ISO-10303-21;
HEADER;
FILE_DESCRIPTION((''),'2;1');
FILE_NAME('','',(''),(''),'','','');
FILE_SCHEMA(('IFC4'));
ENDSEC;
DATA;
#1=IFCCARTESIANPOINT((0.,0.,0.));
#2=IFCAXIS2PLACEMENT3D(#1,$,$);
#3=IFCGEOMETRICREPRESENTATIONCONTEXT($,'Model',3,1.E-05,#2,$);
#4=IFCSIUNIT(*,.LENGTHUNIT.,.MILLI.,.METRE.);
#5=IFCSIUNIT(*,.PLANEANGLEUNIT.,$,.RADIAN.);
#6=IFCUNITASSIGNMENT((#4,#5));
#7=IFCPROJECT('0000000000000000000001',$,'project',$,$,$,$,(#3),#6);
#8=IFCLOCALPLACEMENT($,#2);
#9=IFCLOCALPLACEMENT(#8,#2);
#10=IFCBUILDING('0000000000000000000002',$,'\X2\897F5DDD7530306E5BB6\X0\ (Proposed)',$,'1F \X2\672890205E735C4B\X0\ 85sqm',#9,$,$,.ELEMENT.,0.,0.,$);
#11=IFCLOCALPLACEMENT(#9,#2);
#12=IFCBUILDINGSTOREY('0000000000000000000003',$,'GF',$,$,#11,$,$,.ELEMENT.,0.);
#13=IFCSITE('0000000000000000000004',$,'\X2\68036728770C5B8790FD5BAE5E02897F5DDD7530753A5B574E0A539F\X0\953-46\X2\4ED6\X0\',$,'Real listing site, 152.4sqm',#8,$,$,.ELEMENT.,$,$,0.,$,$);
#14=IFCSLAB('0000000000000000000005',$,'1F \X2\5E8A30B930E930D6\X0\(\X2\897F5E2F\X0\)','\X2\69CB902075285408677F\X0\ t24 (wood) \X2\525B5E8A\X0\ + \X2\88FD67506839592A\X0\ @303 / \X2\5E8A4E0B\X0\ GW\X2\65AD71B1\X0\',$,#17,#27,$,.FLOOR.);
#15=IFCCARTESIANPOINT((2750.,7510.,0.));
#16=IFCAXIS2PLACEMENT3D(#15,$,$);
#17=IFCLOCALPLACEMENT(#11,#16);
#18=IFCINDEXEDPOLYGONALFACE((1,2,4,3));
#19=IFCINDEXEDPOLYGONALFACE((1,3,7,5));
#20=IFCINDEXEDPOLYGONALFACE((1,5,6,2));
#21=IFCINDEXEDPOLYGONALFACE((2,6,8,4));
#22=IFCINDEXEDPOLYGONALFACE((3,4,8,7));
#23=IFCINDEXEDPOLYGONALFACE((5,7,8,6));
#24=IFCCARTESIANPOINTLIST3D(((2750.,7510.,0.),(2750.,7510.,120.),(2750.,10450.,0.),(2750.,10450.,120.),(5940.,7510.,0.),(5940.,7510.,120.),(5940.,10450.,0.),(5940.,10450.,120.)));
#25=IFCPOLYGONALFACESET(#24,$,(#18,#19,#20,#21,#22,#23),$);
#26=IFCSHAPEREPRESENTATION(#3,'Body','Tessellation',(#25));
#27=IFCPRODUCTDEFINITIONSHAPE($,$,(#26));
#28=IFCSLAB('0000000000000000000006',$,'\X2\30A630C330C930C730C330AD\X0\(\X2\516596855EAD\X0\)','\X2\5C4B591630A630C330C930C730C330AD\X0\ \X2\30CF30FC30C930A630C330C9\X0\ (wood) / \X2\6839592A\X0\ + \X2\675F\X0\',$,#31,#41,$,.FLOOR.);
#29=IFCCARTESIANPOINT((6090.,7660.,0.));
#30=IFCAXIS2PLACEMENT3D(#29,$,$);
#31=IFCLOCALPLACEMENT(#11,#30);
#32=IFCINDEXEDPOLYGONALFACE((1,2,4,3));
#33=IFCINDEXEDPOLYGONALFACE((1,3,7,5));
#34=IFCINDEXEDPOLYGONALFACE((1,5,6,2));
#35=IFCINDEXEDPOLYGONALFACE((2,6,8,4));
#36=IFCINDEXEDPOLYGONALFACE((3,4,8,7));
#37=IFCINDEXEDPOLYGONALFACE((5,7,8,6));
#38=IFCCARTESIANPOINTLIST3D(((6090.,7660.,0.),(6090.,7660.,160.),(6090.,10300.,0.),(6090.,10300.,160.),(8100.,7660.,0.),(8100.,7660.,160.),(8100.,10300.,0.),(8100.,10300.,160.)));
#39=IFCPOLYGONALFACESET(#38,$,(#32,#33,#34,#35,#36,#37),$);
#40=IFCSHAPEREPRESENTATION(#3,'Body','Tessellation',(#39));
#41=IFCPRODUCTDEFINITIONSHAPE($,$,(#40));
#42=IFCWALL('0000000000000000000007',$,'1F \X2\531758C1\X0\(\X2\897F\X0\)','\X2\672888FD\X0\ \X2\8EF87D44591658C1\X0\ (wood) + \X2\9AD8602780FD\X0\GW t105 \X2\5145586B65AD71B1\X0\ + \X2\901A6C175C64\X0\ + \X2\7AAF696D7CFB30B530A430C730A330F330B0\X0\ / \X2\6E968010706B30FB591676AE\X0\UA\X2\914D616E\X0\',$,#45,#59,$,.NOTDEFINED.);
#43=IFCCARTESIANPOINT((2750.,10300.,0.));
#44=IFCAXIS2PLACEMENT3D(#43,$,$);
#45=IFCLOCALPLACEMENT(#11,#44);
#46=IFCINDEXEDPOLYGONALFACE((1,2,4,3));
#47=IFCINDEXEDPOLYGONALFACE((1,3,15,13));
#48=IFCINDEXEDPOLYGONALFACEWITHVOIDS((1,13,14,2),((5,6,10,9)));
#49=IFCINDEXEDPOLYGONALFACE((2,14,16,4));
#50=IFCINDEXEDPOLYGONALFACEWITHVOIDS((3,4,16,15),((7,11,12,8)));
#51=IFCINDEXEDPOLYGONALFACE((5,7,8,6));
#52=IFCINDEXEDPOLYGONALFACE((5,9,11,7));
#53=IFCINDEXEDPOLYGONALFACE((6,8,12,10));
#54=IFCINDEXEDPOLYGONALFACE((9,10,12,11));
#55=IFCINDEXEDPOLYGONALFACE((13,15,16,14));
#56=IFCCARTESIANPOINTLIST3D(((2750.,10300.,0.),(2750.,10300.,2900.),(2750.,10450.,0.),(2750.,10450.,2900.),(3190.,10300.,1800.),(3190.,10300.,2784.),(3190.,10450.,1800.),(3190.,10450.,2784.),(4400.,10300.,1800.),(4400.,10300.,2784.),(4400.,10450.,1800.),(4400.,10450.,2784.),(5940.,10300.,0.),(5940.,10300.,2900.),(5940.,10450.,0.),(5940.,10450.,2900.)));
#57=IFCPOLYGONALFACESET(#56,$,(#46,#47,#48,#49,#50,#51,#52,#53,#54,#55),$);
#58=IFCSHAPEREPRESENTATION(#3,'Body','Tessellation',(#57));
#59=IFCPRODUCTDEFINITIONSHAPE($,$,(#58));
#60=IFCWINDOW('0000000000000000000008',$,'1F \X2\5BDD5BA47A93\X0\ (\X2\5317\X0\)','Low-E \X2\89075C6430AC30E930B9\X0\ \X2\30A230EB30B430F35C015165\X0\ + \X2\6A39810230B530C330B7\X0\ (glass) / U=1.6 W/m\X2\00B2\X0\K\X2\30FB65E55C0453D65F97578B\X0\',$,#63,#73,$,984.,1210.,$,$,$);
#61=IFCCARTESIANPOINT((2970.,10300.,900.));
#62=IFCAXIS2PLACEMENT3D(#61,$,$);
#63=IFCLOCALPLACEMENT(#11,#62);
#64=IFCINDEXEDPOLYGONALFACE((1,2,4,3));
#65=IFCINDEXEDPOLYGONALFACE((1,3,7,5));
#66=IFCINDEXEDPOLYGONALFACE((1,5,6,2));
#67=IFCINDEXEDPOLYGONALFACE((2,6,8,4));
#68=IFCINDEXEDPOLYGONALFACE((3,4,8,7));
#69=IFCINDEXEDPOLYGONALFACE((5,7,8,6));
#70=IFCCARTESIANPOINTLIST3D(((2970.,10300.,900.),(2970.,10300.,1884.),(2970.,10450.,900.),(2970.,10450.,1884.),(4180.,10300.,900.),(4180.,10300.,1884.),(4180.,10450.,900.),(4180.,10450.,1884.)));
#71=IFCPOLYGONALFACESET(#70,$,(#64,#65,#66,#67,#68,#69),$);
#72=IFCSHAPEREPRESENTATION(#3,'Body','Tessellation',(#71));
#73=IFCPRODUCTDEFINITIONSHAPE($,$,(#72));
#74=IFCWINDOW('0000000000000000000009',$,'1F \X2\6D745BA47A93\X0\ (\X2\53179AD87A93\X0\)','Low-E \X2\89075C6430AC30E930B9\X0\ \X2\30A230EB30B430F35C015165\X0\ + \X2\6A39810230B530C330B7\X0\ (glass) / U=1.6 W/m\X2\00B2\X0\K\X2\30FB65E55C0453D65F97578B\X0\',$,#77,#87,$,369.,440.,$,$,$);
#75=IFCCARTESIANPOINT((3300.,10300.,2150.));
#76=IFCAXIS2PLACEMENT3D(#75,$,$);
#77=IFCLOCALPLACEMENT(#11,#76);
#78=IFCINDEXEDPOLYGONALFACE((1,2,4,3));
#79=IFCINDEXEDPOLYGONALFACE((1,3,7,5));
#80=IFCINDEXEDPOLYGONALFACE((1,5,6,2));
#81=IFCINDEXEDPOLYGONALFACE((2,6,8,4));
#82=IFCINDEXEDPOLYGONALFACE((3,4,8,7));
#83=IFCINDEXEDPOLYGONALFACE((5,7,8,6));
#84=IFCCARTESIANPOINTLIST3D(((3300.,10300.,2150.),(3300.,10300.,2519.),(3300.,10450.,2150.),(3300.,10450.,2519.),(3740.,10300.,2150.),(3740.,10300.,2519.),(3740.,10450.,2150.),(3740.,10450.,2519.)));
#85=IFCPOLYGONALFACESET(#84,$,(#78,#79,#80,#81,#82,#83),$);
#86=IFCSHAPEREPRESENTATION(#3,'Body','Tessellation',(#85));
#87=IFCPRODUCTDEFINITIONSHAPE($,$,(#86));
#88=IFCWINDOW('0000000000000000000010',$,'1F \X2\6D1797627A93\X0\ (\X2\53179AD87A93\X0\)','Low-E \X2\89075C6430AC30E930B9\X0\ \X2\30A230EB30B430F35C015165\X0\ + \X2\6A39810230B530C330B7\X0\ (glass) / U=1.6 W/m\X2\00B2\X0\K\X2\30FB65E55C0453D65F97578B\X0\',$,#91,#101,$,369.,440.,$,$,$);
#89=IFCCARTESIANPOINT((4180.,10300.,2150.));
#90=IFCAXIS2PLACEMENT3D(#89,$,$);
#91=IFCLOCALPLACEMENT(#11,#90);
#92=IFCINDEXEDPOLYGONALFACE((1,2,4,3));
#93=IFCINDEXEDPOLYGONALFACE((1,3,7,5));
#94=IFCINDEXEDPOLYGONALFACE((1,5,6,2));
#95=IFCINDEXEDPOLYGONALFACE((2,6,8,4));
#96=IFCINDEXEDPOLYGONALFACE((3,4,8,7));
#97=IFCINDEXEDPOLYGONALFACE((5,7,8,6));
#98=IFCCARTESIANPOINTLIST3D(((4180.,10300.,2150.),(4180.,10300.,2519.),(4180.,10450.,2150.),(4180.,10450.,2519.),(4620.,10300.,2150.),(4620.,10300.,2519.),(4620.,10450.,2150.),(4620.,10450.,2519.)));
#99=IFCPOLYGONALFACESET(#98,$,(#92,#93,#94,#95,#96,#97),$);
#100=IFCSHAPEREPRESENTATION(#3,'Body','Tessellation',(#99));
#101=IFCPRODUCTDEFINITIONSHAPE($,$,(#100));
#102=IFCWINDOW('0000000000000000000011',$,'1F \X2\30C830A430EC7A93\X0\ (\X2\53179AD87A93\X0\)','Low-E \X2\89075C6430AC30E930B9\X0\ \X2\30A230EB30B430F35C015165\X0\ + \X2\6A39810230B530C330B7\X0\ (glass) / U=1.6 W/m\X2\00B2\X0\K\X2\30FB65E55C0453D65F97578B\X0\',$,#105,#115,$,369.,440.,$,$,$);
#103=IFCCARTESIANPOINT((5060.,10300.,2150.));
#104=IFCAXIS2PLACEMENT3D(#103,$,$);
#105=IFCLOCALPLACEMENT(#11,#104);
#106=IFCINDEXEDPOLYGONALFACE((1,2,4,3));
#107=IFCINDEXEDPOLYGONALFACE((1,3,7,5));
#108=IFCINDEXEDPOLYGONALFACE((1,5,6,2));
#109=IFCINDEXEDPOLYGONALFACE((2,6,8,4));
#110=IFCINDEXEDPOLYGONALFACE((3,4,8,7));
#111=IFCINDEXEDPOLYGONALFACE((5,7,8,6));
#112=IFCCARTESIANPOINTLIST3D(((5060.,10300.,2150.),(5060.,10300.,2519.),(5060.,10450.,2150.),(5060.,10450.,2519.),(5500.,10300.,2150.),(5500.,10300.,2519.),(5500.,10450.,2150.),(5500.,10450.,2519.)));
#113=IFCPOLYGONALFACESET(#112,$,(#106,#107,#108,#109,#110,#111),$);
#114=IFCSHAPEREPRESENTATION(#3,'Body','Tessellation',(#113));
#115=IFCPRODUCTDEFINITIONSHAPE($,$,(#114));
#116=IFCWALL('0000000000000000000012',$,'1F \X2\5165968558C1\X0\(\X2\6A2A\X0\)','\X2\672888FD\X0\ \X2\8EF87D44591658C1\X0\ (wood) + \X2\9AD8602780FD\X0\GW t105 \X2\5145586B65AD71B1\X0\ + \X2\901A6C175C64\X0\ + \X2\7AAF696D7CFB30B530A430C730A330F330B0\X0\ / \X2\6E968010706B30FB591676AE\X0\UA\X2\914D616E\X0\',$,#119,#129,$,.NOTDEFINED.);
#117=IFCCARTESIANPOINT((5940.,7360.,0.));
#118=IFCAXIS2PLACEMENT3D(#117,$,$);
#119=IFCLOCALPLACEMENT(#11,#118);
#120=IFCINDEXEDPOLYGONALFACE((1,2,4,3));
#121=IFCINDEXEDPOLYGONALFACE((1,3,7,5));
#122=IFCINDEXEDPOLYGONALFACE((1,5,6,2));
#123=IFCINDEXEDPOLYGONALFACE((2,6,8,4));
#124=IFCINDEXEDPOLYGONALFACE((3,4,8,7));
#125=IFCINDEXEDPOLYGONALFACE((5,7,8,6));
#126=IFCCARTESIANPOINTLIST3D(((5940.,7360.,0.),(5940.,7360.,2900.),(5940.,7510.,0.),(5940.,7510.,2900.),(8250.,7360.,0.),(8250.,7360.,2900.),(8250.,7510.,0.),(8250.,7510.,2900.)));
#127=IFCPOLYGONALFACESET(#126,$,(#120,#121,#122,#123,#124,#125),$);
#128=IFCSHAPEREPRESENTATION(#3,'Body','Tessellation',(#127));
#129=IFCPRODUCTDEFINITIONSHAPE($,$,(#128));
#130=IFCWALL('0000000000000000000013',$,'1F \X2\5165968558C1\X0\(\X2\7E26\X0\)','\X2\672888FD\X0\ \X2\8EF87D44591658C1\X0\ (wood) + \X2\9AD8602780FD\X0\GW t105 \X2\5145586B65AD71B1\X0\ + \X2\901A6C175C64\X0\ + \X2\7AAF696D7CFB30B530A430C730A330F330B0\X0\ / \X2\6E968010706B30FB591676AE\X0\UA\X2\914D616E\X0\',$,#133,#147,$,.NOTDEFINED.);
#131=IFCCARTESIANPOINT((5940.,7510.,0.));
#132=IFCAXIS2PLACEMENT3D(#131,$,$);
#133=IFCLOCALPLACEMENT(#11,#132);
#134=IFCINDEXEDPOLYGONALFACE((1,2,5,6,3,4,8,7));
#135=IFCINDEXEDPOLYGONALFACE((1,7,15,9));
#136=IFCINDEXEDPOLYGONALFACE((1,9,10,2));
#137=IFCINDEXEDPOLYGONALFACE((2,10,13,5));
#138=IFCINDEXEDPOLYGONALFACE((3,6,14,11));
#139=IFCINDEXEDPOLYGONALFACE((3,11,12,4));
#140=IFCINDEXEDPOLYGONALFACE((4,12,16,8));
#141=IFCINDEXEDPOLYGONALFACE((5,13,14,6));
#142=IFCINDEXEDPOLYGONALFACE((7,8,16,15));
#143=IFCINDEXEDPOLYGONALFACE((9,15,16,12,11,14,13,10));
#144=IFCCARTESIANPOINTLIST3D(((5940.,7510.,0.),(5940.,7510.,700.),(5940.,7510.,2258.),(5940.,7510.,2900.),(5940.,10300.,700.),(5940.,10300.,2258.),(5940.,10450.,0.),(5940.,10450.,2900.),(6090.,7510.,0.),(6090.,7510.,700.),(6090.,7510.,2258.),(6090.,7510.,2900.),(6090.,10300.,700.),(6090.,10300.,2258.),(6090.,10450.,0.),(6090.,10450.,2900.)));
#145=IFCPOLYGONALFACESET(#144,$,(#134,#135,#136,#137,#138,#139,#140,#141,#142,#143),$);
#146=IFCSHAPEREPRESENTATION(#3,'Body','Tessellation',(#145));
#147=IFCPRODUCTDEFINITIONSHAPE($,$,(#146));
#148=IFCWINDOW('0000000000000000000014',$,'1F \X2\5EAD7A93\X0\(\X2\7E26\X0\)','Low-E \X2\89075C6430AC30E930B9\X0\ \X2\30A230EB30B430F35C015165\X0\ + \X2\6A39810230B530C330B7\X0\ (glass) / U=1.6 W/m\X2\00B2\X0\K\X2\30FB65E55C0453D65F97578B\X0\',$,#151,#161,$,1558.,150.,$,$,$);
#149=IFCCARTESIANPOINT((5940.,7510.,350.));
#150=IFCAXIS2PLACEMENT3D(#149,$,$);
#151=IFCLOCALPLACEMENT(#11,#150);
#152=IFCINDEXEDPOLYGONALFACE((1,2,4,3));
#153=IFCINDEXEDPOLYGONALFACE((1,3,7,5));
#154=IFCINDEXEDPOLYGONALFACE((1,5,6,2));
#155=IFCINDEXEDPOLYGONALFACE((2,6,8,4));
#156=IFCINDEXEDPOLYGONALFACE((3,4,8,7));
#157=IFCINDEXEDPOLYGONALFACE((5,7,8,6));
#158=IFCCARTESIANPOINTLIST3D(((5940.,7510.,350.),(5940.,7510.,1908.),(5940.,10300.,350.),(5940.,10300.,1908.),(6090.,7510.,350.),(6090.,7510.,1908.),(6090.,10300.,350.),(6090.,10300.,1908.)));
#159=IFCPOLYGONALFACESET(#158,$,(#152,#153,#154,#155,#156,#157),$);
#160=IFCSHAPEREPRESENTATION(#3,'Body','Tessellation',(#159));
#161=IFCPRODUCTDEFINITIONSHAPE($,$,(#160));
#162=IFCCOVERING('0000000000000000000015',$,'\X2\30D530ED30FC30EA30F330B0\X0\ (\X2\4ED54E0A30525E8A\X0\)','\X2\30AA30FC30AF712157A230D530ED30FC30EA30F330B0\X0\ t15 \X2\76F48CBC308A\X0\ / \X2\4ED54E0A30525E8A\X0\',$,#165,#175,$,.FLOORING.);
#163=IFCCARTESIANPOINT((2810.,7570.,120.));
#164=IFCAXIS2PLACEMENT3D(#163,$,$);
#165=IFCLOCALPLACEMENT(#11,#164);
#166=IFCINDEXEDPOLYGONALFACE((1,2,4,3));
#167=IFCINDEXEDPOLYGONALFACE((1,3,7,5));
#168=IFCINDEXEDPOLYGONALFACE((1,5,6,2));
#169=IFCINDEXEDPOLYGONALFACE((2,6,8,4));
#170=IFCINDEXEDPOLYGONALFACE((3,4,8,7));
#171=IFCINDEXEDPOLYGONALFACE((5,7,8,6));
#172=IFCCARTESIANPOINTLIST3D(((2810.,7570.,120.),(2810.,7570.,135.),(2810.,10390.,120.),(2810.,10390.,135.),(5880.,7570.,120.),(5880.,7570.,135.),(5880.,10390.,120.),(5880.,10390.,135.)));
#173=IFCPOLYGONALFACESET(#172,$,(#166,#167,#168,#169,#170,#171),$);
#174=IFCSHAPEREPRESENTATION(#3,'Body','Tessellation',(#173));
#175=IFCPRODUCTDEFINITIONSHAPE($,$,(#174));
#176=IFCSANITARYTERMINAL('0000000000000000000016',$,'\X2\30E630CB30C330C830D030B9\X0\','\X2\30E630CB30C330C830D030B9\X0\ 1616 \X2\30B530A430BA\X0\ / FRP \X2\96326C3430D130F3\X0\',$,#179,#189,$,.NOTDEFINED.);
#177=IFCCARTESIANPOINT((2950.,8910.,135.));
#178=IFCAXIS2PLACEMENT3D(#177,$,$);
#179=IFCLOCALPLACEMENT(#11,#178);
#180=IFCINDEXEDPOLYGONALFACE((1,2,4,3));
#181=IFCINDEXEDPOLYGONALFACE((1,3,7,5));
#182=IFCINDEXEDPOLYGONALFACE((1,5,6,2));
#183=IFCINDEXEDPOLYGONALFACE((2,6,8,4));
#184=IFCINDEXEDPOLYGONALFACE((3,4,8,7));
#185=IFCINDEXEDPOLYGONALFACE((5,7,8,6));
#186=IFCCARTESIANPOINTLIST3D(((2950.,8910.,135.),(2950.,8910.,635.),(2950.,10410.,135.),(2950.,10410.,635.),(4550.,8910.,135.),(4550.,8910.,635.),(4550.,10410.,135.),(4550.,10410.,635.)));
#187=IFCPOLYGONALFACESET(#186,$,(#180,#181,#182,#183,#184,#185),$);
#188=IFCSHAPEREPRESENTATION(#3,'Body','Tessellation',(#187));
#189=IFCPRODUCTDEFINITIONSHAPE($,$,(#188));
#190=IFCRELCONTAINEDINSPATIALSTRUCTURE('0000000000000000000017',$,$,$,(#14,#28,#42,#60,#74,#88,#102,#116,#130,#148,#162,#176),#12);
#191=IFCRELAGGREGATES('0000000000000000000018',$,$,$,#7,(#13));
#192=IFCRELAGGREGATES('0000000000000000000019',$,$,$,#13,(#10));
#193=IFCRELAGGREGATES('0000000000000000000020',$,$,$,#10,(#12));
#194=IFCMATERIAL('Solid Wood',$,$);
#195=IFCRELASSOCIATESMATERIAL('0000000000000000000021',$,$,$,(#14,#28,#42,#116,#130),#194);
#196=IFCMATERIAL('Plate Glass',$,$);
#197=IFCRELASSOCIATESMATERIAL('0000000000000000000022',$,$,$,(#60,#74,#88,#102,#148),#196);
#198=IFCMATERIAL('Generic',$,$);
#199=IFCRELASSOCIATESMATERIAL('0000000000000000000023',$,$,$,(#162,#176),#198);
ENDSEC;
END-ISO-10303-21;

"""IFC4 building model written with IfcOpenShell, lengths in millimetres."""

from ifc_helpers import new_model, si_unit, frame, frame_2d, origin, place, context, project, spatial, rectangle, extrude, material, element, fill, save


model = new_model("IFC4")

# Units and contexts
model_context = context("Model", 3, precision=1e-05, world=origin())
ifc_project = project(units=[si_unit("LENGTHUNIT", "METRE", prefix="MILLI"), si_unit("PLANEANGLEUNIT", "RADIAN")], contexts=[model_context])

# Site, building, storey
site_placement = place(None, origin())
site = spatial("IfcSite", under=ifc_project, at=site_placement, Name="栃木県宇都宮市西川田町字上原953-46他", ObjectType="Real listing site, 152.4sqm", CompositionType="ELEMENT", RefElevation=0.0)
building_placement = place(site_placement, origin())
building = spatial("IfcBuilding", under=site, at=building_placement, Name="西川田の家 (Proposed)", ObjectType="1F 木造平屋 85sqm", CompositionType="ELEMENT", ElevationOfRefHeight=0.0, ElevationOfTerrain=0.0)
storey_placement = place(building_placement, origin())
storey = spatial("IfcBuildingStorey", under=building, at=storey_placement, Name="GF", CompositionType="ELEMENT", Elevation=0.0)

# Slabs
ifc_material_1 = material(Name="Solid Wood")
slab_1_placement = place(storey_placement, frame((2750.0, 7510.0, 0.0)))
element("IfcSlab", 1, at=slab_1_placement, inside=storey, material=ifc_material_1, Name="1F 床スラブ(西帯)", Description="構造用合板 t24 (wood) 剛床 + 製材根太 @303 / 床下 GW断熱", PredefinedType="FLOOR", context=model_context, shape_type="SweptSolid", body=[
    extrude(rectangle(XDim=3190.0, YDim=2940.0, at=frame_2d((1595.0, 1470.0))), frame((2750.0, 7510.0, 0.0)), (0.0, 0.0, 1.0), 120.0),
])
slab_2_placement = place(storey_placement, frame((6090.0, 7660.0, 0.0)))
element("IfcSlab", 2, at=slab_2_placement, inside=storey, material=ifc_material_1, Name="ウッドデッキ(入隅庭)", Description="屋外ウッドデッキ ハードウッド (wood) / 根太 + 束", PredefinedType="FLOOR", context=model_context, shape_type="SweptSolid", body=[
    extrude(rectangle(XDim=2010.0, YDim=2640.0, at=frame_2d((1005.0, 1320.0))), frame((6090.0, 7660.0, 0.0)), (0.0, 0.0, 1.0), 160.0),
])

# Wall, openings, windows
wall_1_placement = place(storey_placement, frame((2750.0, 10300.0, 0.0)))
wall_1 = element("IfcWall", 3, at=wall_1_placement, inside=storey, material=ifc_material_1, Name="1F 北壁(西)", Description="木製 軸組外壁 (wood) + 高性能GW t105 充填断熱 + 通気層 + 窯業系サイディング / 準耐火・外皮UA配慮", PredefinedType="NOTDEFINED", context=model_context, shape_type="SweptSolid", body=[
    extrude(rectangle(XDim=3190.0, YDim=150.0, at=frame_2d((1595.0, 75.0))), frame((2750.0, 10300.0, 0.0)), (0.0, 0.0, 1.0), 2900.0),
])
opening_1_placement = place(storey_placement, frame((2970.0, 10300.0, 900.0)))
opening_1 = element("IfcOpeningElement", 4, at=opening_1_placement, cuts=wall_1, PredefinedType="NOTDEFINED", context=model_context, shape_type="SweptSolid", body=[
    extrude(rectangle(XDim=1210.0, YDim=150.0, at=frame_2d((605.0, 75.0))), frame((2970.0, 10300.0, 900.0)), (0.0, 0.0, 1.0), 984.0),
])
opening_2_placement = place(storey_placement, frame((3300.0, 10300.0, 2150.0)))
opening_2 = element("IfcOpeningElement", 5, at=opening_2_placement, cuts=wall_1, PredefinedType="NOTDEFINED", context=model_context, shape_type="SweptSolid", body=[
    extrude(rectangle(XDim=440.0, YDim=150.0, at=frame_2d((220.0, 75.0))), frame((3300.0, 10300.0, 2150.0)), (0.0, 0.0, 1.0), 369.0),
])
opening_3_placement = place(storey_placement, frame((4180.0, 10300.0, 2150.0)))
opening_3 = element("IfcOpeningElement", 6, at=opening_3_placement, cuts=wall_1, PredefinedType="NOTDEFINED", context=model_context, shape_type="SweptSolid", body=[
    extrude(rectangle(XDim=440.0, YDim=150.0, at=frame_2d((220.0, 75.0))), frame((4180.0, 10300.0, 2150.0)), (0.0, 0.0, 1.0), 369.0),
])
opening_4_placement = place(storey_placement, frame((5060.0, 10300.0, 2150.0)))
opening_4 = element("IfcOpeningElement", 7, at=opening_4_placement, cuts=wall_1, PredefinedType="NOTDEFINED", context=model_context, shape_type="SweptSolid", body=[
    extrude(rectangle(XDim=440.0, YDim=150.0, at=frame_2d((220.0, 75.0))), frame((5060.0, 10300.0, 2150.0)), (0.0, 0.0, 1.0), 369.0),
])
ifc_material_2 = material(Name="Plate Glass")
window_1_placement = place(storey_placement, frame((2970.0, 10300.0, 900.0)))
window_1 = element("IfcWindow", 8, at=window_1_placement, inside=storey, material=ifc_material_2, Name="1F 寝室窓 (北)", Description="Low-E 複層ガラス アルゴン封入 + 樹脂サッシ (glass) / U=1.6 W/m²K・日射取得型", OverallHeight=984.0, OverallWidth=1210.0, context=model_context, shape_type="SweptSolid", body=[
    extrude(rectangle(XDim=1210.0, YDim=150.0, at=frame_2d((605.0, 75.0))), frame((2970.0, 10300.0, 900.0)), (0.0, 0.0, 1.0), 984.0),
])
fill(opening_1, window_1)
window_2_placement = place(storey_placement, frame((3300.0, 10300.0, 2150.0)))
window_2 = element("IfcWindow", 9, at=window_2_placement, inside=storey, material=ifc_material_2, Name="1F 浴室窓 (北高窓)", Description="Low-E 複層ガラス アルゴン封入 + 樹脂サッシ (glass) / U=1.6 W/m²K・日射取得型", OverallHeight=369.0, OverallWidth=440.0, context=model_context, shape_type="SweptSolid", body=[
    extrude(rectangle(XDim=440.0, YDim=150.0, at=frame_2d((220.0, 75.0))), frame((3300.0, 10300.0, 2150.0)), (0.0, 0.0, 1.0), 369.0),
])
fill(opening_2, window_2)
window_3_placement = place(storey_placement, frame((4180.0, 10300.0, 2150.0)))
window_3 = element("IfcWindow", 10, at=window_3_placement, inside=storey, material=ifc_material_2, Name="1F 洗面窓 (北高窓)", Description="Low-E 複層ガラス アルゴン封入 + 樹脂サッシ (glass) / U=1.6 W/m²K・日射取得型", OverallHeight=369.0, OverallWidth=440.0, context=model_context, shape_type="SweptSolid", body=[
    extrude(rectangle(XDim=440.0, YDim=150.0, at=frame_2d((220.0, 75.0))), frame((4180.0, 10300.0, 2150.0)), (0.0, 0.0, 1.0), 369.0),
])
fill(opening_3, window_3)
window_4_placement = place(storey_placement, frame((5060.0, 10300.0, 2150.0)))
window_4 = element("IfcWindow", 11, at=window_4_placement, inside=storey, material=ifc_material_2, Name="1F トイレ窓 (北高窓)", Description="Low-E 複層ガラス アルゴン封入 + 樹脂サッシ (glass) / U=1.6 W/m²K・日射取得型", OverallHeight=369.0, OverallWidth=440.0, context=model_context, shape_type="SweptSolid", body=[
    extrude(rectangle(XDim=440.0, YDim=150.0, at=frame_2d((220.0, 75.0))), frame((5060.0, 10300.0, 2150.0)), (0.0, 0.0, 1.0), 369.0),
])
fill(opening_4, window_4)

# Wall
wall_2_placement = place(storey_placement, frame((5940.0, 7360.0, 0.0)))
element("IfcWall", 12, at=wall_2_placement, inside=storey, material=ifc_material_1, Name="1F 入隅壁(横)", Description="木製 軸組外壁 (wood) + 高性能GW t105 充填断熱 + 通気層 + 窯業系サイディング / 準耐火・外皮UA配慮", PredefinedType="NOTDEFINED", context=model_context, shape_type="SweptSolid", body=[
    extrude(rectangle(XDim=2310.0, YDim=150.0, at=frame_2d((1155.0, 75.0))), frame((5940.0, 7360.0, 0.0)), (0.0, 0.0, 1.0), 2900.0),
])

# Wall, opening, window
wall_3_placement = place(storey_placement, frame((5940.0, 7510.0, 0.0)))
wall_3 = element("IfcWall", 13, at=wall_3_placement, inside=storey, material=ifc_material_1, Name="1F 入隅壁(縦)", Description="木製 軸組外壁 (wood) + 高性能GW t105 充填断熱 + 通気層 + 窯業系サイディング / 準耐火・外皮UA配慮", PredefinedType="NOTDEFINED", context=model_context, shape_type="SweptSolid", body=[
    extrude(rectangle(XDim=150.0, YDim=2940.0, at=frame_2d((75.0, 1470.0))), frame((5940.0, 7510.0, 0.0)), (0.0, 0.0, 1.0), 2900.0),
])
opening_5_placement = place(storey_placement, frame((5940.0, 7510.0, 350.0)))
opening_5 = element("IfcOpeningElement", 14, at=opening_5_placement, cuts=wall_3, PredefinedType="NOTDEFINED", context=model_context, shape_type="SweptSolid", body=[
    extrude(rectangle(XDim=150.0, YDim=2790.0, at=frame_2d((75.0, 1395.0))), frame((5940.0, 7510.0, 350.0)), (0.0, 0.0, 1.0), 1558.0),
])
window_5_placement = place(storey_placement, frame((5940.0, 7510.0, 350.0)))
window_5 = element("IfcWindow", 15, at=window_5_placement, inside=storey, material=ifc_material_2, Name="1F 庭窓(縦)", Description="Low-E 複層ガラス アルゴン封入 + 樹脂サッシ (glass) / U=1.6 W/m²K・日射取得型", OverallHeight=1558.0, OverallWidth=150.0, context=model_context, shape_type="SweptSolid", body=[
    extrude(rectangle(XDim=150.0, YDim=2790.0, at=frame_2d((75.0, 1395.0))), frame((5940.0, 7510.0, 350.0)), (0.0, 0.0, 1.0), 1558.0),
])
fill(opening_5, window_5)

# Covering
ifc_material_3 = material(Name="Generic")
covering_placement = place(storey_placement, frame((2810.0, 7570.0, 120.0)))
element("IfcCovering", 16, at=covering_placement, inside=storey, material=ifc_material_3, Name="フローリング (仕上げ床)", Description="オーク無垢フローリング t15 直貼り / 仕上げ床", PredefinedType="FLOORING", context=model_context, shape_type="SweptSolid", body=[
    extrude(rectangle(XDim=3070.0, YDim=2820.0, at=frame_2d((1535.0, 1410.0))), frame((2810.0, 7570.0, 120.0)), (0.0, 0.0, 1.0), 15.0),
])

# Sanitary terminal
sanitary_terminal_1_placement = place(storey_placement, frame((2950.0, 8910.0, 135.0)))
element("IfcSanitaryTerminal", 17, at=sanitary_terminal_1_placement, inside=storey, material=ifc_material_3, Name="ユニットバス", Description="ユニットバス 1616 サイズ / FRP 防水パン", PredefinedType="NOTDEFINED", context=model_context, shape_type="SweptSolid", body=[
    extrude(rectangle(XDim=1600.0, YDim=1500.0, at=frame_2d((800.0, 750.0))), frame((2950.0, 8910.0, 135.0)), (0.0, 0.0, 1.0), 500.0),
])

save(model, "model.ifc")
